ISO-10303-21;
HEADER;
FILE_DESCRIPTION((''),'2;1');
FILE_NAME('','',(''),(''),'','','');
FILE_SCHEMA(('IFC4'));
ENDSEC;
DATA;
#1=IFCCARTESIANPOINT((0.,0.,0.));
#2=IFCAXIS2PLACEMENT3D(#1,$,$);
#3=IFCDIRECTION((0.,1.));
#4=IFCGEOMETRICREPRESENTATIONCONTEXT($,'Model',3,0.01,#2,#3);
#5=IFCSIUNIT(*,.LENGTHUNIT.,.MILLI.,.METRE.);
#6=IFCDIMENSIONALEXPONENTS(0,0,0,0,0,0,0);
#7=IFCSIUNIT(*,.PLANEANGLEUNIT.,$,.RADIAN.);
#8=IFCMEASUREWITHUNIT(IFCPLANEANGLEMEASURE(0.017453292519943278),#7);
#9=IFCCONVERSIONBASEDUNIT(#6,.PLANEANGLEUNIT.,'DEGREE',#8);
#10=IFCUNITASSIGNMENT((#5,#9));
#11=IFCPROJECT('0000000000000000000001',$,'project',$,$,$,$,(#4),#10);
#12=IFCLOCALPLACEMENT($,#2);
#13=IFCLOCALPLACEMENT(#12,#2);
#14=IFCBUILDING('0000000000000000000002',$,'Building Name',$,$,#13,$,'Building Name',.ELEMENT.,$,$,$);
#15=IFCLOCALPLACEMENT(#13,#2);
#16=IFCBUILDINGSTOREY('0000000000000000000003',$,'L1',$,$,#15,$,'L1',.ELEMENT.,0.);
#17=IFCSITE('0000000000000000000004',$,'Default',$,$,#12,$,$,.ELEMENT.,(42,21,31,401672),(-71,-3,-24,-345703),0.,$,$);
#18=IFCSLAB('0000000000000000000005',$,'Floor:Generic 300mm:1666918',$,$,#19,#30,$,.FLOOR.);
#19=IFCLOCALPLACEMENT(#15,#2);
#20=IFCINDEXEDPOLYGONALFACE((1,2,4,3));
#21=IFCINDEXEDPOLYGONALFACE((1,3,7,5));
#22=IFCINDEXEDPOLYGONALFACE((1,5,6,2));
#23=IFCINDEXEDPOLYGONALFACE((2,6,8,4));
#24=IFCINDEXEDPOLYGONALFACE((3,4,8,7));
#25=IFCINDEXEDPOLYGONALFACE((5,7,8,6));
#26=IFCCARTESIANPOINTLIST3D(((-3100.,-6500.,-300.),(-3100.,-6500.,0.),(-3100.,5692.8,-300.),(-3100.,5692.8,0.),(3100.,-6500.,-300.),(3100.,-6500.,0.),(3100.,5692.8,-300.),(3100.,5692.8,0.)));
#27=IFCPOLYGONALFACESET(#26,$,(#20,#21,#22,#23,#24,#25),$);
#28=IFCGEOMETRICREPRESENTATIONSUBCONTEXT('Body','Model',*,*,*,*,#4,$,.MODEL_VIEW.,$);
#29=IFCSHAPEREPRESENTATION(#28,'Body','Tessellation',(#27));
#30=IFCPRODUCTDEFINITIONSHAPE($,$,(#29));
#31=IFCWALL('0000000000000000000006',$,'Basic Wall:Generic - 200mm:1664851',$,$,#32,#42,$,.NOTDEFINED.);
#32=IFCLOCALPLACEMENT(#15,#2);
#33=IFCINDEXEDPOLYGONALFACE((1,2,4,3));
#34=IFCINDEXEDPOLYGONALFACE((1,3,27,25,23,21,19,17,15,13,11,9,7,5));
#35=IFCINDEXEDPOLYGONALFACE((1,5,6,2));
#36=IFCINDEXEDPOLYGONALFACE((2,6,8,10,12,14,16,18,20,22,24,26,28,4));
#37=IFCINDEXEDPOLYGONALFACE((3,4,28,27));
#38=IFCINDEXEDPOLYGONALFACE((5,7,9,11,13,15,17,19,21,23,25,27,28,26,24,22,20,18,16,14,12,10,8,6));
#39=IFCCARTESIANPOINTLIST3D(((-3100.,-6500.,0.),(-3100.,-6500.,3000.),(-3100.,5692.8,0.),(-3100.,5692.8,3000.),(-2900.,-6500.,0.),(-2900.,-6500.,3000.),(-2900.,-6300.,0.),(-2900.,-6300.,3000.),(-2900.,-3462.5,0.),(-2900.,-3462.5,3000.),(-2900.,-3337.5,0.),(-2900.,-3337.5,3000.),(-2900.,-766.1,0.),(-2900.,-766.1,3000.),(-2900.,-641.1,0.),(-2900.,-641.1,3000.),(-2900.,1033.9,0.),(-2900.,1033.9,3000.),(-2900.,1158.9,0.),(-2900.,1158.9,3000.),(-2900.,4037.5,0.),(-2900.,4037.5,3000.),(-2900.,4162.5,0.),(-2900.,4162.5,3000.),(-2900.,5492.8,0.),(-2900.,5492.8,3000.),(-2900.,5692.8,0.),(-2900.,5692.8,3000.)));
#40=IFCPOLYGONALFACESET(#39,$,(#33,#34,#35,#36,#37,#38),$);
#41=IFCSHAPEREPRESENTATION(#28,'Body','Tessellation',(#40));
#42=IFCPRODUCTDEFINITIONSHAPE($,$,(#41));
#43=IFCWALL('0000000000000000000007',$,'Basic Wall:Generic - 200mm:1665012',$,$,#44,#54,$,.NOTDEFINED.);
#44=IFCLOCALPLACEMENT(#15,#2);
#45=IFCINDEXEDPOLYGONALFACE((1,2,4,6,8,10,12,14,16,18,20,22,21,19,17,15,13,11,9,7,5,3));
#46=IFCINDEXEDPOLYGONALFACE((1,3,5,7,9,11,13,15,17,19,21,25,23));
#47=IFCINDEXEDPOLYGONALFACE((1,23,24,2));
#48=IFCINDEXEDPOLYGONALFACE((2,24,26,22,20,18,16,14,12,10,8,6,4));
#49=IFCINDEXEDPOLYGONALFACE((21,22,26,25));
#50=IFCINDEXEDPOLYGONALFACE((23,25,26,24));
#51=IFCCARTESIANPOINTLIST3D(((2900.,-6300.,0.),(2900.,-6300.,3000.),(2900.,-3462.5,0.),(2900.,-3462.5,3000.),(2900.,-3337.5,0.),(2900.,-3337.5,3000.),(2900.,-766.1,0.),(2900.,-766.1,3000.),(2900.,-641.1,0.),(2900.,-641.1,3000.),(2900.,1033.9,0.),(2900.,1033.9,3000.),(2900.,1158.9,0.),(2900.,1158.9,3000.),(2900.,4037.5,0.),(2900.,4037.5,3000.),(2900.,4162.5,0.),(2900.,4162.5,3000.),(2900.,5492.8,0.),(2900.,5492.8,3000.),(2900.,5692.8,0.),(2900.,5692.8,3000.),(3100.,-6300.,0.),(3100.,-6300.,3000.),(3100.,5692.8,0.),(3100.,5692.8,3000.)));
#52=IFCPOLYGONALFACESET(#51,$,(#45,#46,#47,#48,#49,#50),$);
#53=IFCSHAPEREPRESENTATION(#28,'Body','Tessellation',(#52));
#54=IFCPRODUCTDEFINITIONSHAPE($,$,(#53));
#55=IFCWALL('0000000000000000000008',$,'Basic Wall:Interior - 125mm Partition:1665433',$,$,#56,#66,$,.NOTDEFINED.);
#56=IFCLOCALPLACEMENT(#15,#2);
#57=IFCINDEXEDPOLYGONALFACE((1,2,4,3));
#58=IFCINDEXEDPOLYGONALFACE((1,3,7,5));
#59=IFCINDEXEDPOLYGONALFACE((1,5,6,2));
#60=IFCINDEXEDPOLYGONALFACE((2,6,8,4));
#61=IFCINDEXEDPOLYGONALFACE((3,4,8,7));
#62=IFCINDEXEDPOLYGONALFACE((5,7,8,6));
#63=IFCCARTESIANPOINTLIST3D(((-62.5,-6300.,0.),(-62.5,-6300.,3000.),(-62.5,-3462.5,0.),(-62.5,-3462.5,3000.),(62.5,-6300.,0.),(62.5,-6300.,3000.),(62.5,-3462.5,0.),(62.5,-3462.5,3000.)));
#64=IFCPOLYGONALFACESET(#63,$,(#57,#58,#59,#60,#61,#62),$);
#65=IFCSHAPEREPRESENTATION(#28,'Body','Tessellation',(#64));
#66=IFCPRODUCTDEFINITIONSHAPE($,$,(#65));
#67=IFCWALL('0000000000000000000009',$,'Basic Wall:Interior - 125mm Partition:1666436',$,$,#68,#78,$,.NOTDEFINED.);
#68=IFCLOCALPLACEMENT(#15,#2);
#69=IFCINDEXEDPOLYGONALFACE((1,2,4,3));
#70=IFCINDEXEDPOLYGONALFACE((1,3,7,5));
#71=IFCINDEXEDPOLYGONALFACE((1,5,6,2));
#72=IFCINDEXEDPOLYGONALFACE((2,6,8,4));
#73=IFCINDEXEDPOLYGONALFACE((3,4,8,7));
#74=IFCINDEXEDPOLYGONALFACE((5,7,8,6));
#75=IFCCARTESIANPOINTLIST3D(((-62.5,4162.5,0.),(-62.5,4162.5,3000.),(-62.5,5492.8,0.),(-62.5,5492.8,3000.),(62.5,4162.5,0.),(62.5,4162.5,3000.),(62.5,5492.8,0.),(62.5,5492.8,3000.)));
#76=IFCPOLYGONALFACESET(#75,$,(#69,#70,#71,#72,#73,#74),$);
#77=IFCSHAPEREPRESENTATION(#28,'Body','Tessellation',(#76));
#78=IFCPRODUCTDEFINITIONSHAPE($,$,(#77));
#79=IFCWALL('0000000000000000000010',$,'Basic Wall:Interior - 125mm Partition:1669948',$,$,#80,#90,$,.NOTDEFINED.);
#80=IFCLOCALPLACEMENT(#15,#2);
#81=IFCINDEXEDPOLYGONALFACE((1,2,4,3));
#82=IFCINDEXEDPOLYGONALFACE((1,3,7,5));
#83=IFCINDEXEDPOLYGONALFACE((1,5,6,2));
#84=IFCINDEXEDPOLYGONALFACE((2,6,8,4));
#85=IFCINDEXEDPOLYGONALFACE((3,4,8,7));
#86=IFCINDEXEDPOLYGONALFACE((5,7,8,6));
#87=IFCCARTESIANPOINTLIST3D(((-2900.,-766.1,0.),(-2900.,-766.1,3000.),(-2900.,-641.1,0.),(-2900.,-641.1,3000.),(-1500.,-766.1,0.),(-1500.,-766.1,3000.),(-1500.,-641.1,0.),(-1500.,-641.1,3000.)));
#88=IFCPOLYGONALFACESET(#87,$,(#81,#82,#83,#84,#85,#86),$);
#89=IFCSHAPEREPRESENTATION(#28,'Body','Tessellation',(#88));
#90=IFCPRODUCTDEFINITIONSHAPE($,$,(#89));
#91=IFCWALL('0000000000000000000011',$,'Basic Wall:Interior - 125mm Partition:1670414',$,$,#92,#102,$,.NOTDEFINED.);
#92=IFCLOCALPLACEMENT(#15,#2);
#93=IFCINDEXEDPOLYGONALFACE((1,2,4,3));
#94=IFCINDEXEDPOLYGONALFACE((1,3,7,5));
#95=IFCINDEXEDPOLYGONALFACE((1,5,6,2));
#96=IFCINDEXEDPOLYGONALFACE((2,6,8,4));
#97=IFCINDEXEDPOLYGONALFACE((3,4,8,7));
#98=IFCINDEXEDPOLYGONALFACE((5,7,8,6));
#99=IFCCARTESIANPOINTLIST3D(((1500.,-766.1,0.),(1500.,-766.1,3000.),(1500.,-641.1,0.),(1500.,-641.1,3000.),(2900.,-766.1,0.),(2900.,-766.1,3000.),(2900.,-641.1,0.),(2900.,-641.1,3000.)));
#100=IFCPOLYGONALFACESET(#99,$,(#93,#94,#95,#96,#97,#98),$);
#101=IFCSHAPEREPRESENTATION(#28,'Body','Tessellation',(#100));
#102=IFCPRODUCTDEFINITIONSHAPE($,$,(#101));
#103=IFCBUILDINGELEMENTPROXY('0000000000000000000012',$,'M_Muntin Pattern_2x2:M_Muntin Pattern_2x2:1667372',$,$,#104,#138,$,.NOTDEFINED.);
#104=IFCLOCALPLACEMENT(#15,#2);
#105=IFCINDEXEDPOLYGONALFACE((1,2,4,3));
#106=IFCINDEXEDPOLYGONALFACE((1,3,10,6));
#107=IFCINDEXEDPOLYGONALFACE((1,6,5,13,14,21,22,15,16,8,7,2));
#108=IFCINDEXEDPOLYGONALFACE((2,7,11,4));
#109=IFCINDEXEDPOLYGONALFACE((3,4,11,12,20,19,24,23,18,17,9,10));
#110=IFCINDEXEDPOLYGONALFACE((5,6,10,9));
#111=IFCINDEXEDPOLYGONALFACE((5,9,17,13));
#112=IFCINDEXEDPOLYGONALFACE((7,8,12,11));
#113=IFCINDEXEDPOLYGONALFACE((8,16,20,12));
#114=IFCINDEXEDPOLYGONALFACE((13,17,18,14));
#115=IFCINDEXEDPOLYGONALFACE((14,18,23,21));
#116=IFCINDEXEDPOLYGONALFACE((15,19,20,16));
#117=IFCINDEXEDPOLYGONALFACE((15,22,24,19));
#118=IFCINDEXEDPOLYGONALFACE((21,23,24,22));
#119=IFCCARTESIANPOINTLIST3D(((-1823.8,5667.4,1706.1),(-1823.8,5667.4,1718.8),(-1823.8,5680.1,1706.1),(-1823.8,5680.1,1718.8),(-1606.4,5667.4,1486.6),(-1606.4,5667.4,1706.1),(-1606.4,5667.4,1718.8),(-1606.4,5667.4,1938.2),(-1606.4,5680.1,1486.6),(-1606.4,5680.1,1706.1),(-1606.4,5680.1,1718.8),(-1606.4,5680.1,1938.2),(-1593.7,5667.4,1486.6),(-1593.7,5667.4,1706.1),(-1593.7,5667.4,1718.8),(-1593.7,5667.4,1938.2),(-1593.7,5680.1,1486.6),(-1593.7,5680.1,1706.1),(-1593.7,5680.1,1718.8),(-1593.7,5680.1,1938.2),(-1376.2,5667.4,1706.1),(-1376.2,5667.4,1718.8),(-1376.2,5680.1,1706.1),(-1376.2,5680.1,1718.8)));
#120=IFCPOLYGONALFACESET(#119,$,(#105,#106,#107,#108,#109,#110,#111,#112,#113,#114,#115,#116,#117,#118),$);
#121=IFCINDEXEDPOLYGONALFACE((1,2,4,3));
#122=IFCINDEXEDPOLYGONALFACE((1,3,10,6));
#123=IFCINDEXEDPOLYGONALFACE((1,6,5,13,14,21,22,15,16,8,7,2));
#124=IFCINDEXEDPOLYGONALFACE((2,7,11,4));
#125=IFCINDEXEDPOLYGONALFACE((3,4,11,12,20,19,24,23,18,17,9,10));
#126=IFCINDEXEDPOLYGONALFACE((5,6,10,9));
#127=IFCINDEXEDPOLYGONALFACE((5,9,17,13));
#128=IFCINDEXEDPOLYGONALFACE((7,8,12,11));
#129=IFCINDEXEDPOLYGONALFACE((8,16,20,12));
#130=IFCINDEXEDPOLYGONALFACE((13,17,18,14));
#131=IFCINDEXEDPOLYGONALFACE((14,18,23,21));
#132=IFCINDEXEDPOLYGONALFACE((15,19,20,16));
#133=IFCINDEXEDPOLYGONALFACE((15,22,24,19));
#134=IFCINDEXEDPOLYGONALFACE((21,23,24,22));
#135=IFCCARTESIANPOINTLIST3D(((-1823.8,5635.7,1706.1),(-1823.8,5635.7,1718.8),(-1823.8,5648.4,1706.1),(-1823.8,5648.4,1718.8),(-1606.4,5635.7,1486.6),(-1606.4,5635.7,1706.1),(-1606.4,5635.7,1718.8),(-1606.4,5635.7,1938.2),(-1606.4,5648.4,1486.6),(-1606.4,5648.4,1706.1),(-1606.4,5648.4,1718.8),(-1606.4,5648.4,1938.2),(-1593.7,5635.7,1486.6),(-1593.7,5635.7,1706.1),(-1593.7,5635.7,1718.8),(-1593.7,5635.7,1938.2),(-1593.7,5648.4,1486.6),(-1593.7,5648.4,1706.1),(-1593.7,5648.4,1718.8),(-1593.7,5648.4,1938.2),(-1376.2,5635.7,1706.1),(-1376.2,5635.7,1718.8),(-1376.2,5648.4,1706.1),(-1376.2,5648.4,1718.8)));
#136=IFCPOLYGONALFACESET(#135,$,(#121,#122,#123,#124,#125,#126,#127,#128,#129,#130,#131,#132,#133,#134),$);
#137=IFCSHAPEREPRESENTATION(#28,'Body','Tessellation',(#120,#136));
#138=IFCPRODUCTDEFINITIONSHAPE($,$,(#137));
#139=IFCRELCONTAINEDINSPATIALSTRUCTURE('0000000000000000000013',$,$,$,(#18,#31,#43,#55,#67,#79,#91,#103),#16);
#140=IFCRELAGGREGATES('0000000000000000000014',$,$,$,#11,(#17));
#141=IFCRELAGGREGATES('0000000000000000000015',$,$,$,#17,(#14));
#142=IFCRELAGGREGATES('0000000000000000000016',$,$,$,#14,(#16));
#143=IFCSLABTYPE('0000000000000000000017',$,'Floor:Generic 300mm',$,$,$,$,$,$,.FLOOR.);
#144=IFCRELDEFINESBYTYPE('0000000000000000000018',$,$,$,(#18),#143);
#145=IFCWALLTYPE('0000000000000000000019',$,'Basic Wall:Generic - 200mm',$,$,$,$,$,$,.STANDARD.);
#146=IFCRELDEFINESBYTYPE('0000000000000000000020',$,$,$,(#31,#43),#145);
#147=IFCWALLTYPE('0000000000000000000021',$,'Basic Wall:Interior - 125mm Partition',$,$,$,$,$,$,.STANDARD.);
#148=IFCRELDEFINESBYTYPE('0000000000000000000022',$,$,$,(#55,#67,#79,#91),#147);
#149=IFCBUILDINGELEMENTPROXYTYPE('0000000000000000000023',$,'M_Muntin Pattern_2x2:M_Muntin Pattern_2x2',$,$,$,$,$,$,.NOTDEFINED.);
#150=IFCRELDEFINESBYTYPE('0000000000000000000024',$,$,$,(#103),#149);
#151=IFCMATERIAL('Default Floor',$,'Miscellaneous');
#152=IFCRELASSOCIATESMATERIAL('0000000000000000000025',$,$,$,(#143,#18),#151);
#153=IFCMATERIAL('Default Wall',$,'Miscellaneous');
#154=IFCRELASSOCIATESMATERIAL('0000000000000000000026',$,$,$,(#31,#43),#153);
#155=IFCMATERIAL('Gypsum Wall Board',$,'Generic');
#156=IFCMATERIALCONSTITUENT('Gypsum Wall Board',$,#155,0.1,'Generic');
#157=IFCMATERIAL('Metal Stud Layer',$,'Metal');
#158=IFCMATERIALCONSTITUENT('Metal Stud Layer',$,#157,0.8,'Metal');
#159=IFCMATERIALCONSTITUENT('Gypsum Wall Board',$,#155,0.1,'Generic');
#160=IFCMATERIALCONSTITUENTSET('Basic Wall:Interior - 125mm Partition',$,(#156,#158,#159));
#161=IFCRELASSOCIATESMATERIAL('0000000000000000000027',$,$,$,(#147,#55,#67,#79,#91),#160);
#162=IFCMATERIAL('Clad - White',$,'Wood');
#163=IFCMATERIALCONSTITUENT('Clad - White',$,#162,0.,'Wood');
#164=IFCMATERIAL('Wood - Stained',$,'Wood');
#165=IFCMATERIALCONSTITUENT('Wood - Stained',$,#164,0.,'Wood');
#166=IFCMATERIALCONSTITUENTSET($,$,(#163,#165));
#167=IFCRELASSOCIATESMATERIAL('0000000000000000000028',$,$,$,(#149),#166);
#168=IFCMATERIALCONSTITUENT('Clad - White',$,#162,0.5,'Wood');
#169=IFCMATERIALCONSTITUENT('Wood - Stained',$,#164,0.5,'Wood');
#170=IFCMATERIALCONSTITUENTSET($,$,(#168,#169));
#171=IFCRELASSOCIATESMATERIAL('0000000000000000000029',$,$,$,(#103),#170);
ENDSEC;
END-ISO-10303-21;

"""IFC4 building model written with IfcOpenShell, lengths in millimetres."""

from ifc_helpers import new_model, entity, si_unit, converted_unit, direction, frame, origin, place, context, subcontext, project, spatial, indexed_curve, outline, extrude, source, transform, mapped, material, constituent, constituent_set, type_object, type_shapes, element, save


model = new_model("IFC4")

# Units and contexts
model_context = context("Model", 3, precision=0.01, world=origin(), true_north=direction((0.0, 1.0)))
body_context = subcontext(model_context, "Body", "Model", "MODEL_VIEW")
ifc_project = project(units=[si_unit("LENGTHUNIT", "METRE", prefix="MILLI"), converted_unit("PLANEANGLEUNIT", "DEGREE", entity("IfcPlaneAngleMeasure", 0.017453292519943278), si_unit("PLANEANGLEUNIT", "RADIAN"), dimensions=[0, 0, 0, 0, 0, 0, 0])], contexts=[model_context])

# Site, building, storey
site_placement = place(None, origin())
site = spatial("IfcSite", under=ifc_project, at=site_placement, Name="Default", CompositionType="ELEMENT", RefLatitude=(42, 21, 31, 401672), RefLongitude=(-71, -3, -24, -345703), RefElevation=0.0)
building_placement = place(site_placement, origin())
building = spatial("IfcBuilding", under=site, at=building_placement, Name="Building Name", LongName="Building Name", CompositionType="ELEMENT")
storey_placement = place(building_placement, origin())
storey = spatial("IfcBuildingStorey", under=building, at=storey_placement, Name="L1", LongName="L1", CompositionType="ELEMENT", Elevation=0.0)

# Slab
ifc_material_1 = material(Name="Default Floor", Category="Miscellaneous")
slab_type = type_object("IfcSlabType", Name="Floor:Generic 300mm", PredefinedType="FLOOR", material=ifc_material_1)
slab_placement = place(storey_placement, origin())
element("IfcSlab", 1, at=slab_placement, inside=storey, type_object=slab_type, material=ifc_material_1, Name="Floor:Generic 300mm:1666918", PredefinedType="FLOOR", context=body_context, shape_type="SweptSolid", body=[
    extrude(outline(indexed_curve([(-6096.4, -3100.0), (6096.4, -3100.0), (6096.4, 3100.0), (-6096.4, 3100.0), (-6096.4, -3100.0)], self_intersect=False)), frame((0.0, -403.6, 0.0), z_axis=(0.0, 0.0, -1.0), x_axis=(0.0, 1.0, 0.0)), (0.0, 0.0, 1.0), 300.0),
])

# Walls
ifc_material_2 = material(Name="Default Wall", Category="Miscellaneous")
wall_type_1 = type_object("IfcWallType", Name="Basic Wall:Generic - 200mm", PredefinedType="STANDARD")
wall_1_placement = place(storey_placement, frame((-3000.0, 5692.8, 0.0), z_axis=(0.0, 0.0, 1.0), x_axis=(0.0, -1.0, 0.0)))
element("IfcWall", 2, at=wall_1_placement, inside=storey, type_object=wall_type_1, material=ifc_material_2, Name="Basic Wall:Generic - 200mm:1664851", PredefinedType="NOTDEFINED", context=body_context, shape_type="SweptSolid", body=[
    extrude(outline(indexed_curve([(12192.8, -100.0), (12192.8, 100.0), (11992.8, 100.0), (9155.3, 100.0), (9030.3, 100.0), (6458.9, 100.0), (6333.9, 100.0), (4658.9, 100.0), (4533.9, 100.0), (1655.3, 100.0), (1530.3, 100.0), (200.0, 100.0), (0.0, 100.0), (0.0, -100.0), (12192.8, -100.0)], self_intersect=False)), origin(), (0.0, 0.0, 1.0), 3000.0),
])
wall_2_placement = place(storey_placement, frame((3000.0, -6300.0, 0.0), z_axis=(0.0, 0.0, 1.0), x_axis=(0.0, 1.0, 0.0)))
element("IfcWall", 3, at=wall_2_placement, inside=storey, type_object=wall_type_1, material=ifc_material_2, Name="Basic Wall:Generic - 200mm:1665012", PredefinedType="NOTDEFINED", context=body_context, shape_type="SweptSolid", body=[
    extrude(outline(indexed_curve([(11992.8, -100.0), (11992.8, 100.0), (11792.8, 100.0), (10462.5, 100.0), (10337.5, 100.0), (7458.9, 100.0), (7333.9, 100.0), (5658.9, 100.0), (5533.9, 100.0), (2962.5, 100.0), (2837.5, 100.0), (0.0, 100.0), (0.0, -100.0), (11992.8, -100.0)], self_intersect=False)), origin(), (0.0, 0.0, 1.0), 3000.0),
])
ifc_material_3 = material(Name="Gypsum Wall Board", Category="Generic")
ifc_constituent_1 = constituent(ifc_material_3, Name="Gypsum Wall Board", Category="Generic", fraction=0.1)
ifc_material_4 = material(Name="Metal Stud Layer", Category="Metal")
ifc_constituent_2 = constituent(ifc_material_4, Name="Metal Stud Layer", Category="Metal", fraction=0.8)
ifc_constituent_3 = constituent(ifc_material_3, Name="Gypsum Wall Board", Category="Generic", fraction=0.1)
ifc_constituent_set_1 = constituent_set(constituents=[ifc_constituent_1, ifc_constituent_2, ifc_constituent_3], Name="Basic Wall:Interior - 125mm Partition")
wall_type_2 = type_object("IfcWallType", Name="Basic Wall:Interior - 125mm Partition", PredefinedType="STANDARD", material=ifc_constituent_set_1)
wall_3_placement = place(storey_placement, frame((0.0, -3462.5, 0.0), z_axis=(0.0, 0.0, 1.0), x_axis=(0.0, -1.0, 0.0)))
element("IfcWall", 4, at=wall_3_placement, inside=storey, type_object=wall_type_2, material=ifc_constituent_set_1, Name="Basic Wall:Interior - 125mm Partition:1665433", PredefinedType="NOTDEFINED", context=body_context, shape_type="SweptSolid", body=[
    extrude(outline(indexed_curve([(2837.5, -62.5), (2837.5, 62.5), (0.0, 62.5), (0.0, -62.5), (2837.5, -62.5)], self_intersect=False)), origin(), (0.0, 0.0, 1.0), 3000.0),
])
wall_4_placement = place(storey_placement, frame((0.0, 5492.8, 0.0), z_axis=(0.0, 0.0, 1.0), x_axis=(0.0, -1.0, 0.0)))
element("IfcWall", 5, at=wall_4_placement, inside=storey, type_object=wall_type_2, material=ifc_constituent_set_1, Name="Basic Wall:Interior - 125mm Partition:1666436", PredefinedType="NOTDEFINED", context=body_context, shape_type="SweptSolid", body=[
    extrude(outline(indexed_curve([(1330.3, -62.5), (1330.3, 62.5), (0.0, 62.5), (0.0, -62.5), (1330.3, -62.5)], self_intersect=False)), origin(), (0.0, 0.0, 1.0), 3000.0),
])
wall_5_placement = place(storey_placement, frame((-2900.0, -703.6, 0.0)))
element("IfcWall", 6, at=wall_5_placement, inside=storey, type_object=wall_type_2, material=ifc_constituent_set_1, Name="Basic Wall:Interior - 125mm Partition:1669948", PredefinedType="NOTDEFINED", context=body_context, shape_type="SweptSolid", body=[
    extrude(outline(indexed_curve([(1400.0, -62.5), (1400.0, 62.5), (0.0, 62.5), (0.0, -62.5), (1400.0, -62.5)], self_intersect=False)), origin(), (0.0, 0.0, 1.0), 3000.0),
])
wall_6_placement = place(storey_placement, frame((2900.0, -703.6, 0.0), z_axis=(0.0, 0.0, 1.0), x_axis=(-1.0, 0.0, 0.0)))
element("IfcWall", 7, at=wall_6_placement, inside=storey, type_object=wall_type_2, material=ifc_constituent_set_1, Name="Basic Wall:Interior - 125mm Partition:1670414", PredefinedType="NOTDEFINED", context=body_context, shape_type="SweptSolid", body=[
    extrude(outline(indexed_curve([(1400.0, -62.5), (1400.0, 62.5), (0.0, 62.5), (0.0, -62.5), (1400.0, -62.5)], self_intersect=False)), origin(), (0.0, 0.0, 1.0), 3000.0),
])

# Building element proxy
ifc_material_5 = material(Name="Clad - White", Category="Wood")
ifc_constituent_4 = constituent(ifc_material_5, Name="Clad - White", Category="Wood", fraction=0.5)
ifc_material_6 = material(Name="Wood - Stained", Category="Wood")
ifc_constituent_5 = constituent(ifc_material_6, Name="Wood - Stained", Category="Wood", fraction=0.5)
ifc_constituent_set_2 = constituent_set(constituents=[ifc_constituent_4, ifc_constituent_5])
ifc_constituent_6 = constituent(ifc_material_5, Name="Clad - White", Category="Wood", fraction=0.0)
ifc_constituent_7 = constituent(ifc_material_6, Name="Wood - Stained", Category="Wood", fraction=0.0)
ifc_constituent_set_3 = constituent_set(constituents=[ifc_constituent_6, ifc_constituent_7])
building_element_proxy_type_1 = type_object("IfcBuildingElementProxyType", Name="M_Muntin Pattern_2x2:M_Muntin Pattern_2x2", PredefinedType="NOTDEFINED", material=ifc_constituent_set_3)
shared_shape_1 = source(origin(), body_context, "Body", "SweptSolid", [
    extrude(outline(indexed_curve([(6.4, -6.4), (225.8, -6.4), (225.8, 6.3), (6.4, 6.3), (6.4, 223.8), (-6.3, 223.8), (-6.3, 6.3), (-225.8, 6.3), (-225.8, -6.4), (-6.3, -6.4), (-6.3, -223.8), (6.4, -223.8), (6.4, -6.4)], self_intersect=False)), frame((0.0, 9.5, 225.8), z_axis=(0.0, 1.0, 0.0), x_axis=(0.0, 0.0, 1.0)), (0.0, 0.0, 1.0), 12.7),
    extrude(outline(indexed_curve([(6.4, -6.4), (225.8, -6.4), (225.8, 6.3), (6.4, 6.3), (6.4, 223.8), (-6.3, 223.8), (-6.3, 6.3), (-225.8, 6.3), (-225.8, -6.4), (-6.3, -6.4), (-6.3, -223.8), (6.4, -223.8), (6.4, -6.4)], self_intersect=False)), frame((0.0, -22.2, 225.8), z_axis=(0.0, 1.0, 0.0), x_axis=(0.0, 0.0, 1.0)), (0.0, 0.0, 1.0), 12.7),
])
type_shapes(building_element_proxy_type_1, [shared_shape_1])
proxy_1_placement = place(storey_placement, frame((-1600.0, 5657.9, 1486.6)))
element("IfcBuildingElementProxy", 8, at=proxy_1_placement, inside=storey, type_object=building_element_proxy_type_1, material=ifc_constituent_set_2, Name="M_Muntin Pattern_2x2:M_Muntin Pattern_2x2:1667372", PredefinedType="NOTDEFINED", context=body_context, shape_type="MappedRepresentation", body=[
    mapped(shared_shape_1, transform((0.0, 0.0, 0.0), scale=1.0)),
])

save(model, "model.ifc")
